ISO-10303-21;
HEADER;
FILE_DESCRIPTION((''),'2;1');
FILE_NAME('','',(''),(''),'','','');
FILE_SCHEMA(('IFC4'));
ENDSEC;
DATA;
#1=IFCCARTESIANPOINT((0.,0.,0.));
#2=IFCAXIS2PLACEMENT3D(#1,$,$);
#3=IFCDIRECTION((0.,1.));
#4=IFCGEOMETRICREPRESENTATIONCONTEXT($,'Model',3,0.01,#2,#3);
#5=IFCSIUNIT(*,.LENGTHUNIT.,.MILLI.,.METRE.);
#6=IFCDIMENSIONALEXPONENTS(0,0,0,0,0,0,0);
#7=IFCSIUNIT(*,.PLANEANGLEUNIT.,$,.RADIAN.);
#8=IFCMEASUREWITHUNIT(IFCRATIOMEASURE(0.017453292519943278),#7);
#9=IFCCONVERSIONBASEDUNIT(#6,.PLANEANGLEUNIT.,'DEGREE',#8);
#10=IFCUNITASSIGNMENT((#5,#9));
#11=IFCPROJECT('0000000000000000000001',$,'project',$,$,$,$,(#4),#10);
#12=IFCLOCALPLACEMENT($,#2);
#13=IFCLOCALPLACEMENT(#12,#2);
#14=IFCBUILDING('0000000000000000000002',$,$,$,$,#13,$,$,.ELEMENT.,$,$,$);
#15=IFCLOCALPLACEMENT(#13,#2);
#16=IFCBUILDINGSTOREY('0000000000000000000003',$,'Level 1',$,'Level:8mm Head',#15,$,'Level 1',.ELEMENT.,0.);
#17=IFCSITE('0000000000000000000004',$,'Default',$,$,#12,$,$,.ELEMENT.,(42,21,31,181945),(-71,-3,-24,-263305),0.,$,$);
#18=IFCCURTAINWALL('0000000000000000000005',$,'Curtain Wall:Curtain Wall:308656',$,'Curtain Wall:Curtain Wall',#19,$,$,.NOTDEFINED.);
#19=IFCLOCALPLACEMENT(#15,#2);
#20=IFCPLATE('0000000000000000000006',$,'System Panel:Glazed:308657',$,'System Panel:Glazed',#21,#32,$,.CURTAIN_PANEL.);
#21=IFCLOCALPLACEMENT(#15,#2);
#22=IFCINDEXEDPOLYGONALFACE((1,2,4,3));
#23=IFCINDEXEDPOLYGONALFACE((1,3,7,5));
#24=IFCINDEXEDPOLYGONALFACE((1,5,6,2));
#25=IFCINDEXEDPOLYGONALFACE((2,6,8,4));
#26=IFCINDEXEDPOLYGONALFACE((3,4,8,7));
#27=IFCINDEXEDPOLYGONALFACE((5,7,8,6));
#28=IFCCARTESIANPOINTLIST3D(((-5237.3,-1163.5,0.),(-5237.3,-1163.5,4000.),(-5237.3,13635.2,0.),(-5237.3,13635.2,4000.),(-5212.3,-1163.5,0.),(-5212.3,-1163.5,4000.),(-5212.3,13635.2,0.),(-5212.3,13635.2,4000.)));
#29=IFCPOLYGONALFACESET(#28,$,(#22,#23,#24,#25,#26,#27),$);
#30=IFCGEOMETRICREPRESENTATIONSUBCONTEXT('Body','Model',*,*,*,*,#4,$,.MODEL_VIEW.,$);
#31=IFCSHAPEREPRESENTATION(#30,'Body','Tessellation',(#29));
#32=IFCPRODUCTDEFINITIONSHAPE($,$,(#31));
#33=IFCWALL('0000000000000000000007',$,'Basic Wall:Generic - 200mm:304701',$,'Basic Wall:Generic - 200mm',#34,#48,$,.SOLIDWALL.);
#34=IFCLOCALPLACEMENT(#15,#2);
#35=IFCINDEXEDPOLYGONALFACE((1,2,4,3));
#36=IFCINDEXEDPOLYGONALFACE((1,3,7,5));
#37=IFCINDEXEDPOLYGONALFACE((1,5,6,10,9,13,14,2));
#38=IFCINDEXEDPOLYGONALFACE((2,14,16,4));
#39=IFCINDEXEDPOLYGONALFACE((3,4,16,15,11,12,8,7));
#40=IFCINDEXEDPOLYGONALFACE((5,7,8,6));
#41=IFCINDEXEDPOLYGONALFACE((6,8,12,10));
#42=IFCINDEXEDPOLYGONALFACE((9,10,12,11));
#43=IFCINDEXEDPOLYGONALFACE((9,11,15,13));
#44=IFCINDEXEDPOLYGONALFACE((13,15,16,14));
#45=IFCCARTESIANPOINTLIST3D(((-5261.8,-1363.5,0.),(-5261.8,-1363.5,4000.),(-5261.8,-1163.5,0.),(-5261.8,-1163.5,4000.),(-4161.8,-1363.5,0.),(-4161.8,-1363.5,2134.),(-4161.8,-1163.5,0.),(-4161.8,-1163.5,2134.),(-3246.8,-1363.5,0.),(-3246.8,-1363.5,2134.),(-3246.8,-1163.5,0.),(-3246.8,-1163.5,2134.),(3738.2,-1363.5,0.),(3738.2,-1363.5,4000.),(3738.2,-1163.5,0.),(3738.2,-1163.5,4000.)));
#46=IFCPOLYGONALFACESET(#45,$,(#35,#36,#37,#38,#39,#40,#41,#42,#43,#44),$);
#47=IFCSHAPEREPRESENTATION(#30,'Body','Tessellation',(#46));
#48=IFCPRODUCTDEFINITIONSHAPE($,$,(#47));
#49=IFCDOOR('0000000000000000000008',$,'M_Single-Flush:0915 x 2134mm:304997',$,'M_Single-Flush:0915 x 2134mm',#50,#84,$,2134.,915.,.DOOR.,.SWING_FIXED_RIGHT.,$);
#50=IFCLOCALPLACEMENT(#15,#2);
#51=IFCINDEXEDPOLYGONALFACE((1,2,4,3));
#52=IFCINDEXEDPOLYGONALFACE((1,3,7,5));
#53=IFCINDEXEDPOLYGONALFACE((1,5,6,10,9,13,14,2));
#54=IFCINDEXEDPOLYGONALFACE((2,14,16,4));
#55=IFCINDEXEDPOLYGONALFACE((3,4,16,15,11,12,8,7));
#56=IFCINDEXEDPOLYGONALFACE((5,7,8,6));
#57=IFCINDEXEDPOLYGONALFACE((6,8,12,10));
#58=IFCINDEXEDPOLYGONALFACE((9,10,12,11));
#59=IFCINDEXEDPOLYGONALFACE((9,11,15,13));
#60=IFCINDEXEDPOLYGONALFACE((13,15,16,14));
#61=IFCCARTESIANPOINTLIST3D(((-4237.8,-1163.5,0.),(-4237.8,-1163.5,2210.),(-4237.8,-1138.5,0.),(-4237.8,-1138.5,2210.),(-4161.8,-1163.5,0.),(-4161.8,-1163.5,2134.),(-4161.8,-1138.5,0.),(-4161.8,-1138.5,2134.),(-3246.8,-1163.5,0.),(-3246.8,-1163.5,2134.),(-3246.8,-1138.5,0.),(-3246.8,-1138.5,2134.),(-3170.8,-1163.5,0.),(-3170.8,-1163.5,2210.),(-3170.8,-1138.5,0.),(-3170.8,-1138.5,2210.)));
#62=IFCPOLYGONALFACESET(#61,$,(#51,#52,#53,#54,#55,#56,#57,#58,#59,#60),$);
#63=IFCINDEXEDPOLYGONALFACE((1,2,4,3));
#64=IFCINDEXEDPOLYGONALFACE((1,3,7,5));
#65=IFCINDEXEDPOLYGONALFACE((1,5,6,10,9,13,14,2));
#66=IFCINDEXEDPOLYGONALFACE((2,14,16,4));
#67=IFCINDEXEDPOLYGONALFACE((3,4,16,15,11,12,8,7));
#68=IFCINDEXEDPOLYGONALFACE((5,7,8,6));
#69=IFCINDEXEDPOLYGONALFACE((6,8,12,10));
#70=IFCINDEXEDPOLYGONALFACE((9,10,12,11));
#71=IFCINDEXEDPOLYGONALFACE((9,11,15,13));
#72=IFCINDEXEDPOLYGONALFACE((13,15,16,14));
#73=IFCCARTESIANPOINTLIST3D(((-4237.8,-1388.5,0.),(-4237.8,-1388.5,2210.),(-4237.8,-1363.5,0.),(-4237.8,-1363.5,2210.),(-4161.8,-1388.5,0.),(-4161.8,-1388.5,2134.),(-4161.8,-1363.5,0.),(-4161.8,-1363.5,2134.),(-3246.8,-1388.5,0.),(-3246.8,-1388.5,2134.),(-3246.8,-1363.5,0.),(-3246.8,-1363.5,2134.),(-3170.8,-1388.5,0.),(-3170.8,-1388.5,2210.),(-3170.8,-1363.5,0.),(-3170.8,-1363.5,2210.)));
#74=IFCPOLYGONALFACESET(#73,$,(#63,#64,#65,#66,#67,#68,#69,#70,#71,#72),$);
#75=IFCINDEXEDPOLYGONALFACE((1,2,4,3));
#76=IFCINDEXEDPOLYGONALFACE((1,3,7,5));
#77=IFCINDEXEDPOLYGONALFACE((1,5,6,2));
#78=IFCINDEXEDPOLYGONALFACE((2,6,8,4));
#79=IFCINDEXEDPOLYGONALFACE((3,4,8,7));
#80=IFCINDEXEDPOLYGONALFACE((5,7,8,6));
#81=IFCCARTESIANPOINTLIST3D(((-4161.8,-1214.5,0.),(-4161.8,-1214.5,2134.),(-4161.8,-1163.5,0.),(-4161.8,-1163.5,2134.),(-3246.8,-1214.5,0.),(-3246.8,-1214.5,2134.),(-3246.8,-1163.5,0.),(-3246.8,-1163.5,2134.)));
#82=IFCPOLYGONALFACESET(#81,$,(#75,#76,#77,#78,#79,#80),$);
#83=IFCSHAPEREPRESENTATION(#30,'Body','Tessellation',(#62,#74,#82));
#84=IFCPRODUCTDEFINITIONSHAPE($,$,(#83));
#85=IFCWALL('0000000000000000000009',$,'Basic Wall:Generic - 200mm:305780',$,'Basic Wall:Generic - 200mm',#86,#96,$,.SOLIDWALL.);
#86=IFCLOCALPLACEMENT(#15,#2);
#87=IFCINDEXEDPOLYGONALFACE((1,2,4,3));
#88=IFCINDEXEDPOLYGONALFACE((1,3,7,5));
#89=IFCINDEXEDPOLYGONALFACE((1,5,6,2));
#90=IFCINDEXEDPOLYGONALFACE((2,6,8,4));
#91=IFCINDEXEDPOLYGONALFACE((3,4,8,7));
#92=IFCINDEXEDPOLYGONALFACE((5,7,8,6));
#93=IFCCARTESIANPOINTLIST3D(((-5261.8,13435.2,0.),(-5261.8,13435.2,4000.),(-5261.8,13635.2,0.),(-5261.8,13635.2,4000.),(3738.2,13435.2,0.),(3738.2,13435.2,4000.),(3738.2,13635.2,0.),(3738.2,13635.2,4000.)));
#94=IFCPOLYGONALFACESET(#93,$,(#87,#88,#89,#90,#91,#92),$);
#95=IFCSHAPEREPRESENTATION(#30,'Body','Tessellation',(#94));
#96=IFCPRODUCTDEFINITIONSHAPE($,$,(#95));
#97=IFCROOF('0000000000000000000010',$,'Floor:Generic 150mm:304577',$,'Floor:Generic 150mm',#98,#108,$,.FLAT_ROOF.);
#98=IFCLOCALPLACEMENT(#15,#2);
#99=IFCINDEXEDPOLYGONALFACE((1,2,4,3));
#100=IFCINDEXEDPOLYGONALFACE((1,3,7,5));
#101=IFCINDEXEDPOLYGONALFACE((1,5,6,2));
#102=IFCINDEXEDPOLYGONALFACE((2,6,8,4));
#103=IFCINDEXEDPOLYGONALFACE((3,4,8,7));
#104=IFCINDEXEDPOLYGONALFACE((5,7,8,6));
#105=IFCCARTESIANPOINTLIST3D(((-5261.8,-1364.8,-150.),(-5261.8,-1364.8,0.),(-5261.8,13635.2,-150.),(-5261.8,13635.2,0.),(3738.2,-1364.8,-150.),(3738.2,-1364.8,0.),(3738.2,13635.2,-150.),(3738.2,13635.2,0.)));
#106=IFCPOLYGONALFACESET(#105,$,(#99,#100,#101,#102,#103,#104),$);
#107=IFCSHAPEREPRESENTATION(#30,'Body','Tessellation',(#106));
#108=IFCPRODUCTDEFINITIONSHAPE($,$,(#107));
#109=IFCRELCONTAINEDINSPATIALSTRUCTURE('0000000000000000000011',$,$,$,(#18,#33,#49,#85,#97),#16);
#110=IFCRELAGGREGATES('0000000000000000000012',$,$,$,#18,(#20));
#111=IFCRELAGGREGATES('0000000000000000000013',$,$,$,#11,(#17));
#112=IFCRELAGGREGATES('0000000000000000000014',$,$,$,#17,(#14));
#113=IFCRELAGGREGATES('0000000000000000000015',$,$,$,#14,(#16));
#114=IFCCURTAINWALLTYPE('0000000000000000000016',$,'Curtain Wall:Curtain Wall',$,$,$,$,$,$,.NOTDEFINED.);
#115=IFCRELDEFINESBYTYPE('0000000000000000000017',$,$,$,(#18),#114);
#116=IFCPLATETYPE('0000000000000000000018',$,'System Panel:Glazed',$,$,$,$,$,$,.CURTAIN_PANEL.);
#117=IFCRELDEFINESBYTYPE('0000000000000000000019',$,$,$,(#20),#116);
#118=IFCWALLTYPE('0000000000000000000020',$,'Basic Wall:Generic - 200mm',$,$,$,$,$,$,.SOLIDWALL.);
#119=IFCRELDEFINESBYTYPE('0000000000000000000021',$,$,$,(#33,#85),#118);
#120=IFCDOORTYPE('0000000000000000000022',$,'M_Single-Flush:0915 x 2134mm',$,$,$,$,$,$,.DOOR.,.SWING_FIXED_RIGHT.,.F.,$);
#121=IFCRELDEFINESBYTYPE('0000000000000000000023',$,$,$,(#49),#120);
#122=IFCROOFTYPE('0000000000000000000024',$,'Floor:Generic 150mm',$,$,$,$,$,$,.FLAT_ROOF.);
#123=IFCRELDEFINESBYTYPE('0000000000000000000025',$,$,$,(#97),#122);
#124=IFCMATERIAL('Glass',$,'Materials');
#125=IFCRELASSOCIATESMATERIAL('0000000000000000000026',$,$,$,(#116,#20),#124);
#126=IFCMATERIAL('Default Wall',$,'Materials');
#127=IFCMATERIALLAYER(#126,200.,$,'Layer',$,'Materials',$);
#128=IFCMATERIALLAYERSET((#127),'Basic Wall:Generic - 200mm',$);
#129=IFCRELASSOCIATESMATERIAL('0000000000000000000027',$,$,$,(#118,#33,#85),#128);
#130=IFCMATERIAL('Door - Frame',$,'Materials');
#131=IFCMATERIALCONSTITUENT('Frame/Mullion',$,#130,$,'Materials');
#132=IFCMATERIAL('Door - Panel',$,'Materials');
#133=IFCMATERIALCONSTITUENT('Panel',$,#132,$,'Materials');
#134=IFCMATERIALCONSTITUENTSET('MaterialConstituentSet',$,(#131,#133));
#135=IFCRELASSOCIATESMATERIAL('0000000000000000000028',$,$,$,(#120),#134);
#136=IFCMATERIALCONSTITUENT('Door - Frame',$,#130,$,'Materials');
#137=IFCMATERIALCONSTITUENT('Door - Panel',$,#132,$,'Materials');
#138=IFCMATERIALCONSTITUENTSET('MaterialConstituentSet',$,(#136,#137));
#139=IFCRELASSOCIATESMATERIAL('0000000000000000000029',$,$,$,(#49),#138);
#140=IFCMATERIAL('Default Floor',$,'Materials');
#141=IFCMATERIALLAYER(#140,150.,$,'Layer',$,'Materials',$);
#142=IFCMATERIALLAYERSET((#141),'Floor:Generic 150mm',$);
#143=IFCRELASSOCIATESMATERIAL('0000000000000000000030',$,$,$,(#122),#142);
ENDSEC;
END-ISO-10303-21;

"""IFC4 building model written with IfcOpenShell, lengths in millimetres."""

from ifc_helpers import new_model, entity, si_unit, converted_unit, direction, frame, frame_2d, origin, origin_2d_with_axis, place, context, subcontext, project, spatial, polyline, rectangle, outline, extrude, source, transform, mapped, material, layer, layer_set, layer_usage, constituent, constituent_set, type_object, type_shapes, element, fill, aggregate, save


model = new_model("IFC4")

# Units and contexts
model_context = context("Model", 3, precision=0.01, world=origin(), true_north=direction((0.0, 1.0)))
body_context = subcontext(model_context, "Body", "Model", "MODEL_VIEW")
ifc_project = project(units=[si_unit("LENGTHUNIT", "METRE", prefix="MILLI"), converted_unit("PLANEANGLEUNIT", "DEGREE", entity("IfcRatioMeasure", 0.017453292519943278), si_unit("PLANEANGLEUNIT", "RADIAN"), dimensions=[0, 0, 0, 0, 0, 0, 0])], contexts=[model_context])

# Site, building, storey
site_placement = place(None, origin())
site = spatial("IfcSite", under=ifc_project, at=site_placement, Name="Default", CompositionType="ELEMENT", RefLatitude=(42, 21, 31, 181945), RefLongitude=(-71, -3, -24, -263305), RefElevation=0.0)
building_placement = place(site_placement, origin())
building = spatial("IfcBuilding", under=site, at=building_placement, CompositionType="ELEMENT")
storey_placement = place(building_placement, origin())
storey = spatial("IfcBuildingStorey", under=building, at=storey_placement, Name="Level 1", ObjectType="Level:8mm Head", LongName="Level 1", CompositionType="ELEMENT", Elevation=0.0)

# Curtain wall, plate
curtain_wall_type = type_object("IfcCurtainWallType", Name="Curtain Wall:Curtain Wall", PredefinedType="NOTDEFINED")
ifc_material_1 = material(Name="Glass", Category="Materials")
curtain_wall_1_placement = place(storey_placement, origin())
curtain_wall_1 = element("IfcCurtainWall", 1, at=curtain_wall_1_placement, inside=storey, type_object=curtain_wall_type, Name="Curtain Wall:Curtain Wall:308656", ObjectType="Curtain Wall:Curtain Wall", PredefinedType="NOTDEFINED")
plate_type_1 = type_object("IfcPlateType", Name="System Panel:Glazed", PredefinedType="CURTAIN_PANEL", material=ifc_material_1)
shared_shape_1 = source(origin(), body_context, "Body", "SweptSolid", [
    extrude(rectangle(XDim=25.0, YDim=14798.7, at=origin_2d_with_axis()), frame((7399.3, 12.5, 0.0), z_axis=(0.0, 0.0, 1.0), x_axis=(0.0, 1.0, 0.0)), (0.0, 0.0, 1.0), 4000.0),
])
type_shapes(plate_type_1, [shared_shape_1])
plate_1_placement = place(curtain_wall_1_placement, frame((-5237.3, 13635.2, 0.0), z_axis=(0.0, 0.0, 1.0), x_axis=(0.0, -1.0, 0.0)))
plate_1 = element("IfcPlate", 2, at=plate_1_placement, type_object=plate_type_1, material=ifc_material_1, Name="System Panel:Glazed:308657", ObjectType="System Panel:Glazed", PredefinedType="CURTAIN_PANEL", context=body_context, shape_type="MappedRepresentation", body=[
    mapped(shared_shape_1, transform((0.0, 0.0, 0.0), scale=1.0)),
])
aggregate(curtain_wall_1, [plate_1])

# Wall, opening, door
ifc_material_2 = material(Name="Default Wall", Category="Materials")
ifc_layer_1 = layer(ifc_material_2, 200.0, Name="Layer", Category="Materials")
ifc_layer_set_1 = layer_set([ifc_layer_1], Name="Basic Wall:Generic - 200mm")
ifc_layer_usage_1 = layer_usage(ifc_layer_set_1, "AXIS2", "NEGATIVE", 100.0)
wall_type = type_object("IfcWallType", Name="Basic Wall:Generic - 200mm", PredefinedType="SOLIDWALL", material=ifc_layer_set_1)
wall_1_placement = place(storey_placement, frame((-5261.8, -1263.5, 0.0)))
wall_1 = element("IfcWall", 3, at=wall_1_placement, inside=storey, type_object=wall_type, material=ifc_layer_usage_1, Name="Basic Wall:Generic - 200mm:304701", ObjectType="Basic Wall:Generic - 200mm", PredefinedType="SOLIDWALL", context=body_context, shape_type="SweptSolid", body=[
    extrude(rectangle(XDim=9000.0, YDim=200.0, at=frame_2d((4500.0, 0.0), x_axis=(1.0, 0.0))), origin(), (0.0, 0.0, 1.0), 4000.0),
])
opening_placement = place(wall_1_placement, frame((1100.0, -100.0, 0.0)))
opening = element("IfcOpeningElement", 4, at=opening_placement, cuts=wall_1, PredefinedType="OPENING", context=body_context, shape_type="SweptSolid", body=[
    extrude(rectangle(XDim=915.0, YDim=2134.0, at=frame_2d((1067.0, 457.5), x_axis=(0.0, 1.0))), frame((0.0, 0.0, 0.0), z_axis=(0.0, 1.0, 0.0), x_axis=(0.0, 0.0, 1.0)), (0.0, 0.0, 1.0), 200.0),
])
ifc_material_3 = material(Name="Door - Frame", Category="Materials")
ifc_constituent_1 = constituent(ifc_material_3, Name="Door - Frame", Category="Materials")
ifc_material_4 = material(Name="Door - Panel", Category="Materials")
ifc_constituent_2 = constituent(ifc_material_4, Name="Door - Panel", Category="Materials")
ifc_constituent_set_1 = constituent_set(constituents=[ifc_constituent_1, ifc_constituent_2], Name="MaterialConstituentSet")
ifc_constituent_3 = constituent(ifc_material_3, Name="Frame/Mullion", Category="Materials")
ifc_constituent_4 = constituent(ifc_material_4, Name="Panel", Category="Materials")
ifc_constituent_set_2 = constituent_set(constituents=[ifc_constituent_3, ifc_constituent_4], Name="MaterialConstituentSet")
door_type = type_object("IfcDoorType", Name="M_Single-Flush:0915 x 2134mm", OperationType="SWING_FIXED_RIGHT", ParameterTakesPrecedence=False, PredefinedType="DOOR", material=ifc_constituent_set_2)
shared_shape_2 = source(origin(), body_context, "Body", "SweptSolid", [
    extrude(outline(polyline([(-533.5, -1124.0), (533.5, -1124.0), (533.5, 1086.0), (457.5, 1086.0), (457.5, -1048.0), (-457.5, -1048.0), (-457.5, 1086.0), (-533.5, 1086.0), (-533.5, -1124.0)])), frame((457.5, 200.0, 1086.0), z_axis=(0.0, 1.0, 0.0), x_axis=(1.0, 0.0, 0.0)), (0.0, 0.0, 1.0), 25.0),
    extrude(outline(polyline([(-1124.0, -533.5), (1086.0, -533.5), (1086.0, -457.5), (-1048.0, -457.5), (-1048.0, 457.5), (1086.0, 457.5), (1086.0, 533.5), (-1124.0, 533.5), (-1124.0, -533.5)])), frame((457.5, -25.0, 1086.0), z_axis=(0.0, 1.0, 0.0), x_axis=(0.0, 0.0, -1.0)), (0.0, 0.0, 1.0), 25.0),
    extrude(rectangle(XDim=51.0, YDim=915.0, at=frame_2d((0.0, 0.0), x_axis=(1.0, 0.0))), frame((457.5, 174.5, 0.0), z_axis=(0.0, 0.0, 1.0), x_axis=(0.0, 1.0, 0.0)), (0.0, 0.0, 1.0), 2134.0),
])
type_shapes(door_type, [shared_shape_2])
door_placement = place(opening_placement, origin())
door = element("IfcDoor", 5, at=door_placement, inside=storey, type_object=door_type, material=ifc_constituent_set_1, Name="M_Single-Flush:0915 x 2134mm:304997", ObjectType="M_Single-Flush:0915 x 2134mm", OperationType="SWING_FIXED_RIGHT", OverallHeight=2134.0, OverallWidth=915.0, PredefinedType="DOOR", context=body_context, shape_type="MappedRepresentation", body=[
    mapped(shared_shape_2, transform((0.0, 0.0, 0.0), scale=1.0)),
])
fill(opening, door)

# Wall
ifc_layer_usage_2 = layer_usage(ifc_layer_set_1, "AXIS2", "NEGATIVE", 100.0)
wall_2_placement = place(storey_placement, frame((-5261.8, 13535.2, 0.0)))
element("IfcWall", 6, at=wall_2_placement, inside=storey, type_object=wall_type, material=ifc_layer_usage_2, Name="Basic Wall:Generic - 200mm:305780", ObjectType="Basic Wall:Generic - 200mm", PredefinedType="SOLIDWALL", context=body_context, shape_type="SweptSolid", body=[
    extrude(rectangle(XDim=9000.0, YDim=200.0, at=frame_2d((4500.0, 0.0), x_axis=(-1.0, 0.0))), origin(), (0.0, 0.0, 1.0), 4000.0),
])

# Roof
ifc_material_5 = material(Name="Default Floor", Category="Materials")
ifc_layer_2 = layer(ifc_material_5, 150.0, Name="Layer", Category="Materials")
ifc_layer_set_2 = layer_set([ifc_layer_2], Name="Floor:Generic 150mm")
roof_type = type_object("IfcRoofType", Name="Floor:Generic 150mm", PredefinedType="FLAT_ROOF", material=ifc_layer_set_2)
roof_placement = place(storey_placement, origin())
element("IfcRoof", 7, at=roof_placement, inside=storey, type_object=roof_type, Name="Floor:Generic 150mm:304577", ObjectType="Floor:Generic 150mm", PredefinedType="FLAT_ROOF", context=body_context, shape_type="SweptSolid", body=[
    extrude(rectangle(XDim=15000.0, YDim=9000.0, at=origin_2d_with_axis()), frame((-761.8, 6135.2, 0.0), z_axis=(0.0, 0.0, -1.0), x_axis=(0.0, 1.0, 0.0)), (0.0, 0.0, 1.0), 150.0),
])

save(model, "model.ifc")
